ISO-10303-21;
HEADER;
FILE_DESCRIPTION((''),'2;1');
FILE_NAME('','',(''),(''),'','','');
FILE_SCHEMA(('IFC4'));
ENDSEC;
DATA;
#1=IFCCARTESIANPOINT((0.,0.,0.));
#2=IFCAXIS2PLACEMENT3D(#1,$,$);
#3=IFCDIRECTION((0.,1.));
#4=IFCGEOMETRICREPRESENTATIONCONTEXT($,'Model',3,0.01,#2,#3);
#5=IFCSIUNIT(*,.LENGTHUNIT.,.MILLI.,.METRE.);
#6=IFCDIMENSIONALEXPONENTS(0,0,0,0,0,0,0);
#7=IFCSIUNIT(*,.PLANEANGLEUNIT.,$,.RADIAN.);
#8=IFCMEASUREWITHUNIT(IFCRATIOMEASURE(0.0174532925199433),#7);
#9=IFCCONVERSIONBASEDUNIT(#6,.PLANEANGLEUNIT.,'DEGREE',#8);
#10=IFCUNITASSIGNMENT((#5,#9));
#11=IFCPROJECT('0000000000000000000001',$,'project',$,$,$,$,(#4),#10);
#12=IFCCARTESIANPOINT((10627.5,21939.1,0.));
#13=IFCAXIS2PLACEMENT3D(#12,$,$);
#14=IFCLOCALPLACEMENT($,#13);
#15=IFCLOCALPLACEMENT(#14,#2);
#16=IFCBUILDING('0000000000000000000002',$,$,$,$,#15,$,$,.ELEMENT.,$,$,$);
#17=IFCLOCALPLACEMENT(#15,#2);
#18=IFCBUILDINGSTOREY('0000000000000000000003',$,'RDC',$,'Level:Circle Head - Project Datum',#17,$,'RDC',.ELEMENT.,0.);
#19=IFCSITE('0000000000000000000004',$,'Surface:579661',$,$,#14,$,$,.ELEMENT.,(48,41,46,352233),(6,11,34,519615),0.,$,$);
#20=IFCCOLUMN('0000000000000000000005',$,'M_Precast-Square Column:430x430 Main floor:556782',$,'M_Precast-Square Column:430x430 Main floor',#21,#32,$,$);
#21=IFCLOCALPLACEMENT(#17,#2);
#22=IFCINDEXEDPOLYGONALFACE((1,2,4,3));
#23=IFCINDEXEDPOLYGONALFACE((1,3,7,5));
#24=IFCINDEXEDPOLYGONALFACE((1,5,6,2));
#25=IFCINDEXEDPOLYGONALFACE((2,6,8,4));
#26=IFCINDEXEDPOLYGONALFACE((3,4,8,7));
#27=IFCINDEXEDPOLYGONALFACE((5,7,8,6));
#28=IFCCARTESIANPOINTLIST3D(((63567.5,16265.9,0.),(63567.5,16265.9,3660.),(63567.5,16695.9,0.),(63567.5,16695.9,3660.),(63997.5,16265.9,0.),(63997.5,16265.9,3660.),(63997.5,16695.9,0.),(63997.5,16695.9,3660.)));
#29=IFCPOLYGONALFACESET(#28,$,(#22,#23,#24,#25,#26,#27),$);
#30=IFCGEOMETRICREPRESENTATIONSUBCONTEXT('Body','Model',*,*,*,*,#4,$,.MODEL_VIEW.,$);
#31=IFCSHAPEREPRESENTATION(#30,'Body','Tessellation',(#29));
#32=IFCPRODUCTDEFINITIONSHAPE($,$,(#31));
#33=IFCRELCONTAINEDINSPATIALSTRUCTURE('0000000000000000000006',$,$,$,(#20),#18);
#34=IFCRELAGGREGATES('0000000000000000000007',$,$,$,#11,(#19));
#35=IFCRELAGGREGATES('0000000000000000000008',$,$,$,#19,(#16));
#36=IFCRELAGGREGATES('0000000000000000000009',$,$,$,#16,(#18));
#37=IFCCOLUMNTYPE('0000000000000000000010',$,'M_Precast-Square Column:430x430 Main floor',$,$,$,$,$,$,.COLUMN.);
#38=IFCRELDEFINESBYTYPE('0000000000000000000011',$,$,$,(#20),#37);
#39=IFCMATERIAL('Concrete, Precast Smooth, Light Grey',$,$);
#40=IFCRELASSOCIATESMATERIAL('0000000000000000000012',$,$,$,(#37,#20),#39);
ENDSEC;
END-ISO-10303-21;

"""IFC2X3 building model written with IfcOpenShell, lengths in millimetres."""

from ifc_helpers import new_model, entity, si_unit, converted_unit, direction, frame, origin, origin_2d_with_axis, place, context, subcontext, project, spatial, rectangle, extrude, source, transform, mapped, material, type_object, type_shapes, element, save


model = new_model("IFC2X3")

# Units and contexts
model_context = context("Model", 3, precision=0.01, world=origin(), true_north=direction((0.0, 1.0)))
body_context = subcontext(model_context, "Body", "Model", "MODEL_VIEW")
ifc_project = project(units=[si_unit("LENGTHUNIT", "METRE", prefix="MILLI"), converted_unit("PLANEANGLEUNIT", "DEGREE", entity("IfcRatioMeasure", 0.0174532925199433), si_unit("PLANEANGLEUNIT", "RADIAN"), dimensions=[0, 0, 0, 0, 0, 0, 0])], contexts=[model_context])

# Site, building, storey
site_placement = place(None, frame((10627.5, 21939.1, 0.0)))
site = spatial("IfcSite", under=ifc_project, at=site_placement, Name="Surface:579661", CompositionType="ELEMENT", RefLatitude=(48, 41, 46, 352233), RefLongitude=(6, 11, 34, 519615), RefElevation=0.0)
building_placement = place(site_placement, origin())
building = spatial("IfcBuilding", under=site, at=building_placement, CompositionType="ELEMENT")
storey_placement = place(building_placement, origin())
storey = spatial("IfcBuildingStorey", under=building, at=storey_placement, Name="RDC", ObjectType="Level:Circle Head - Project Datum", LongName="RDC", CompositionType="ELEMENT", Elevation=0.0)

# Column
ifc_material = material(Name="Concrete, Precast Smooth, Light Grey")
column_type = type_object("IfcColumnType", Name="M_Precast-Square Column:430x430 Main floor", PredefinedType="COLUMN", material=ifc_material)
shared_shape = source(origin(), body_context, "Body", "SweptSolid", [
    extrude(rectangle(XDim=430.0, YDim=430.0, at=origin_2d_with_axis()), frame((0.0, 0.0, 0.0), z_axis=(0.0, 0.0, 1.0), x_axis=(0.0, -1.0, 0.0)), (0.0, 0.0, 1.0), 3660.0),
])
type_shapes(column_type, [shared_shape])
column_placement = place(storey_placement, frame((63782.5, 16480.9, 0.0)))
element("IfcColumn", 1, at=column_placement, inside=storey, type_object=column_type, material=ifc_material, Name="M_Precast-Square Column:430x430 Main floor:556782", ObjectType="M_Precast-Square Column:430x430 Main floor", context=body_context, shape_type="MappedRepresentation", body=[
    mapped(shared_shape, transform((0.0, 0.0, 0.0), scale=1.0)),
])

save(model, "model.ifc")
